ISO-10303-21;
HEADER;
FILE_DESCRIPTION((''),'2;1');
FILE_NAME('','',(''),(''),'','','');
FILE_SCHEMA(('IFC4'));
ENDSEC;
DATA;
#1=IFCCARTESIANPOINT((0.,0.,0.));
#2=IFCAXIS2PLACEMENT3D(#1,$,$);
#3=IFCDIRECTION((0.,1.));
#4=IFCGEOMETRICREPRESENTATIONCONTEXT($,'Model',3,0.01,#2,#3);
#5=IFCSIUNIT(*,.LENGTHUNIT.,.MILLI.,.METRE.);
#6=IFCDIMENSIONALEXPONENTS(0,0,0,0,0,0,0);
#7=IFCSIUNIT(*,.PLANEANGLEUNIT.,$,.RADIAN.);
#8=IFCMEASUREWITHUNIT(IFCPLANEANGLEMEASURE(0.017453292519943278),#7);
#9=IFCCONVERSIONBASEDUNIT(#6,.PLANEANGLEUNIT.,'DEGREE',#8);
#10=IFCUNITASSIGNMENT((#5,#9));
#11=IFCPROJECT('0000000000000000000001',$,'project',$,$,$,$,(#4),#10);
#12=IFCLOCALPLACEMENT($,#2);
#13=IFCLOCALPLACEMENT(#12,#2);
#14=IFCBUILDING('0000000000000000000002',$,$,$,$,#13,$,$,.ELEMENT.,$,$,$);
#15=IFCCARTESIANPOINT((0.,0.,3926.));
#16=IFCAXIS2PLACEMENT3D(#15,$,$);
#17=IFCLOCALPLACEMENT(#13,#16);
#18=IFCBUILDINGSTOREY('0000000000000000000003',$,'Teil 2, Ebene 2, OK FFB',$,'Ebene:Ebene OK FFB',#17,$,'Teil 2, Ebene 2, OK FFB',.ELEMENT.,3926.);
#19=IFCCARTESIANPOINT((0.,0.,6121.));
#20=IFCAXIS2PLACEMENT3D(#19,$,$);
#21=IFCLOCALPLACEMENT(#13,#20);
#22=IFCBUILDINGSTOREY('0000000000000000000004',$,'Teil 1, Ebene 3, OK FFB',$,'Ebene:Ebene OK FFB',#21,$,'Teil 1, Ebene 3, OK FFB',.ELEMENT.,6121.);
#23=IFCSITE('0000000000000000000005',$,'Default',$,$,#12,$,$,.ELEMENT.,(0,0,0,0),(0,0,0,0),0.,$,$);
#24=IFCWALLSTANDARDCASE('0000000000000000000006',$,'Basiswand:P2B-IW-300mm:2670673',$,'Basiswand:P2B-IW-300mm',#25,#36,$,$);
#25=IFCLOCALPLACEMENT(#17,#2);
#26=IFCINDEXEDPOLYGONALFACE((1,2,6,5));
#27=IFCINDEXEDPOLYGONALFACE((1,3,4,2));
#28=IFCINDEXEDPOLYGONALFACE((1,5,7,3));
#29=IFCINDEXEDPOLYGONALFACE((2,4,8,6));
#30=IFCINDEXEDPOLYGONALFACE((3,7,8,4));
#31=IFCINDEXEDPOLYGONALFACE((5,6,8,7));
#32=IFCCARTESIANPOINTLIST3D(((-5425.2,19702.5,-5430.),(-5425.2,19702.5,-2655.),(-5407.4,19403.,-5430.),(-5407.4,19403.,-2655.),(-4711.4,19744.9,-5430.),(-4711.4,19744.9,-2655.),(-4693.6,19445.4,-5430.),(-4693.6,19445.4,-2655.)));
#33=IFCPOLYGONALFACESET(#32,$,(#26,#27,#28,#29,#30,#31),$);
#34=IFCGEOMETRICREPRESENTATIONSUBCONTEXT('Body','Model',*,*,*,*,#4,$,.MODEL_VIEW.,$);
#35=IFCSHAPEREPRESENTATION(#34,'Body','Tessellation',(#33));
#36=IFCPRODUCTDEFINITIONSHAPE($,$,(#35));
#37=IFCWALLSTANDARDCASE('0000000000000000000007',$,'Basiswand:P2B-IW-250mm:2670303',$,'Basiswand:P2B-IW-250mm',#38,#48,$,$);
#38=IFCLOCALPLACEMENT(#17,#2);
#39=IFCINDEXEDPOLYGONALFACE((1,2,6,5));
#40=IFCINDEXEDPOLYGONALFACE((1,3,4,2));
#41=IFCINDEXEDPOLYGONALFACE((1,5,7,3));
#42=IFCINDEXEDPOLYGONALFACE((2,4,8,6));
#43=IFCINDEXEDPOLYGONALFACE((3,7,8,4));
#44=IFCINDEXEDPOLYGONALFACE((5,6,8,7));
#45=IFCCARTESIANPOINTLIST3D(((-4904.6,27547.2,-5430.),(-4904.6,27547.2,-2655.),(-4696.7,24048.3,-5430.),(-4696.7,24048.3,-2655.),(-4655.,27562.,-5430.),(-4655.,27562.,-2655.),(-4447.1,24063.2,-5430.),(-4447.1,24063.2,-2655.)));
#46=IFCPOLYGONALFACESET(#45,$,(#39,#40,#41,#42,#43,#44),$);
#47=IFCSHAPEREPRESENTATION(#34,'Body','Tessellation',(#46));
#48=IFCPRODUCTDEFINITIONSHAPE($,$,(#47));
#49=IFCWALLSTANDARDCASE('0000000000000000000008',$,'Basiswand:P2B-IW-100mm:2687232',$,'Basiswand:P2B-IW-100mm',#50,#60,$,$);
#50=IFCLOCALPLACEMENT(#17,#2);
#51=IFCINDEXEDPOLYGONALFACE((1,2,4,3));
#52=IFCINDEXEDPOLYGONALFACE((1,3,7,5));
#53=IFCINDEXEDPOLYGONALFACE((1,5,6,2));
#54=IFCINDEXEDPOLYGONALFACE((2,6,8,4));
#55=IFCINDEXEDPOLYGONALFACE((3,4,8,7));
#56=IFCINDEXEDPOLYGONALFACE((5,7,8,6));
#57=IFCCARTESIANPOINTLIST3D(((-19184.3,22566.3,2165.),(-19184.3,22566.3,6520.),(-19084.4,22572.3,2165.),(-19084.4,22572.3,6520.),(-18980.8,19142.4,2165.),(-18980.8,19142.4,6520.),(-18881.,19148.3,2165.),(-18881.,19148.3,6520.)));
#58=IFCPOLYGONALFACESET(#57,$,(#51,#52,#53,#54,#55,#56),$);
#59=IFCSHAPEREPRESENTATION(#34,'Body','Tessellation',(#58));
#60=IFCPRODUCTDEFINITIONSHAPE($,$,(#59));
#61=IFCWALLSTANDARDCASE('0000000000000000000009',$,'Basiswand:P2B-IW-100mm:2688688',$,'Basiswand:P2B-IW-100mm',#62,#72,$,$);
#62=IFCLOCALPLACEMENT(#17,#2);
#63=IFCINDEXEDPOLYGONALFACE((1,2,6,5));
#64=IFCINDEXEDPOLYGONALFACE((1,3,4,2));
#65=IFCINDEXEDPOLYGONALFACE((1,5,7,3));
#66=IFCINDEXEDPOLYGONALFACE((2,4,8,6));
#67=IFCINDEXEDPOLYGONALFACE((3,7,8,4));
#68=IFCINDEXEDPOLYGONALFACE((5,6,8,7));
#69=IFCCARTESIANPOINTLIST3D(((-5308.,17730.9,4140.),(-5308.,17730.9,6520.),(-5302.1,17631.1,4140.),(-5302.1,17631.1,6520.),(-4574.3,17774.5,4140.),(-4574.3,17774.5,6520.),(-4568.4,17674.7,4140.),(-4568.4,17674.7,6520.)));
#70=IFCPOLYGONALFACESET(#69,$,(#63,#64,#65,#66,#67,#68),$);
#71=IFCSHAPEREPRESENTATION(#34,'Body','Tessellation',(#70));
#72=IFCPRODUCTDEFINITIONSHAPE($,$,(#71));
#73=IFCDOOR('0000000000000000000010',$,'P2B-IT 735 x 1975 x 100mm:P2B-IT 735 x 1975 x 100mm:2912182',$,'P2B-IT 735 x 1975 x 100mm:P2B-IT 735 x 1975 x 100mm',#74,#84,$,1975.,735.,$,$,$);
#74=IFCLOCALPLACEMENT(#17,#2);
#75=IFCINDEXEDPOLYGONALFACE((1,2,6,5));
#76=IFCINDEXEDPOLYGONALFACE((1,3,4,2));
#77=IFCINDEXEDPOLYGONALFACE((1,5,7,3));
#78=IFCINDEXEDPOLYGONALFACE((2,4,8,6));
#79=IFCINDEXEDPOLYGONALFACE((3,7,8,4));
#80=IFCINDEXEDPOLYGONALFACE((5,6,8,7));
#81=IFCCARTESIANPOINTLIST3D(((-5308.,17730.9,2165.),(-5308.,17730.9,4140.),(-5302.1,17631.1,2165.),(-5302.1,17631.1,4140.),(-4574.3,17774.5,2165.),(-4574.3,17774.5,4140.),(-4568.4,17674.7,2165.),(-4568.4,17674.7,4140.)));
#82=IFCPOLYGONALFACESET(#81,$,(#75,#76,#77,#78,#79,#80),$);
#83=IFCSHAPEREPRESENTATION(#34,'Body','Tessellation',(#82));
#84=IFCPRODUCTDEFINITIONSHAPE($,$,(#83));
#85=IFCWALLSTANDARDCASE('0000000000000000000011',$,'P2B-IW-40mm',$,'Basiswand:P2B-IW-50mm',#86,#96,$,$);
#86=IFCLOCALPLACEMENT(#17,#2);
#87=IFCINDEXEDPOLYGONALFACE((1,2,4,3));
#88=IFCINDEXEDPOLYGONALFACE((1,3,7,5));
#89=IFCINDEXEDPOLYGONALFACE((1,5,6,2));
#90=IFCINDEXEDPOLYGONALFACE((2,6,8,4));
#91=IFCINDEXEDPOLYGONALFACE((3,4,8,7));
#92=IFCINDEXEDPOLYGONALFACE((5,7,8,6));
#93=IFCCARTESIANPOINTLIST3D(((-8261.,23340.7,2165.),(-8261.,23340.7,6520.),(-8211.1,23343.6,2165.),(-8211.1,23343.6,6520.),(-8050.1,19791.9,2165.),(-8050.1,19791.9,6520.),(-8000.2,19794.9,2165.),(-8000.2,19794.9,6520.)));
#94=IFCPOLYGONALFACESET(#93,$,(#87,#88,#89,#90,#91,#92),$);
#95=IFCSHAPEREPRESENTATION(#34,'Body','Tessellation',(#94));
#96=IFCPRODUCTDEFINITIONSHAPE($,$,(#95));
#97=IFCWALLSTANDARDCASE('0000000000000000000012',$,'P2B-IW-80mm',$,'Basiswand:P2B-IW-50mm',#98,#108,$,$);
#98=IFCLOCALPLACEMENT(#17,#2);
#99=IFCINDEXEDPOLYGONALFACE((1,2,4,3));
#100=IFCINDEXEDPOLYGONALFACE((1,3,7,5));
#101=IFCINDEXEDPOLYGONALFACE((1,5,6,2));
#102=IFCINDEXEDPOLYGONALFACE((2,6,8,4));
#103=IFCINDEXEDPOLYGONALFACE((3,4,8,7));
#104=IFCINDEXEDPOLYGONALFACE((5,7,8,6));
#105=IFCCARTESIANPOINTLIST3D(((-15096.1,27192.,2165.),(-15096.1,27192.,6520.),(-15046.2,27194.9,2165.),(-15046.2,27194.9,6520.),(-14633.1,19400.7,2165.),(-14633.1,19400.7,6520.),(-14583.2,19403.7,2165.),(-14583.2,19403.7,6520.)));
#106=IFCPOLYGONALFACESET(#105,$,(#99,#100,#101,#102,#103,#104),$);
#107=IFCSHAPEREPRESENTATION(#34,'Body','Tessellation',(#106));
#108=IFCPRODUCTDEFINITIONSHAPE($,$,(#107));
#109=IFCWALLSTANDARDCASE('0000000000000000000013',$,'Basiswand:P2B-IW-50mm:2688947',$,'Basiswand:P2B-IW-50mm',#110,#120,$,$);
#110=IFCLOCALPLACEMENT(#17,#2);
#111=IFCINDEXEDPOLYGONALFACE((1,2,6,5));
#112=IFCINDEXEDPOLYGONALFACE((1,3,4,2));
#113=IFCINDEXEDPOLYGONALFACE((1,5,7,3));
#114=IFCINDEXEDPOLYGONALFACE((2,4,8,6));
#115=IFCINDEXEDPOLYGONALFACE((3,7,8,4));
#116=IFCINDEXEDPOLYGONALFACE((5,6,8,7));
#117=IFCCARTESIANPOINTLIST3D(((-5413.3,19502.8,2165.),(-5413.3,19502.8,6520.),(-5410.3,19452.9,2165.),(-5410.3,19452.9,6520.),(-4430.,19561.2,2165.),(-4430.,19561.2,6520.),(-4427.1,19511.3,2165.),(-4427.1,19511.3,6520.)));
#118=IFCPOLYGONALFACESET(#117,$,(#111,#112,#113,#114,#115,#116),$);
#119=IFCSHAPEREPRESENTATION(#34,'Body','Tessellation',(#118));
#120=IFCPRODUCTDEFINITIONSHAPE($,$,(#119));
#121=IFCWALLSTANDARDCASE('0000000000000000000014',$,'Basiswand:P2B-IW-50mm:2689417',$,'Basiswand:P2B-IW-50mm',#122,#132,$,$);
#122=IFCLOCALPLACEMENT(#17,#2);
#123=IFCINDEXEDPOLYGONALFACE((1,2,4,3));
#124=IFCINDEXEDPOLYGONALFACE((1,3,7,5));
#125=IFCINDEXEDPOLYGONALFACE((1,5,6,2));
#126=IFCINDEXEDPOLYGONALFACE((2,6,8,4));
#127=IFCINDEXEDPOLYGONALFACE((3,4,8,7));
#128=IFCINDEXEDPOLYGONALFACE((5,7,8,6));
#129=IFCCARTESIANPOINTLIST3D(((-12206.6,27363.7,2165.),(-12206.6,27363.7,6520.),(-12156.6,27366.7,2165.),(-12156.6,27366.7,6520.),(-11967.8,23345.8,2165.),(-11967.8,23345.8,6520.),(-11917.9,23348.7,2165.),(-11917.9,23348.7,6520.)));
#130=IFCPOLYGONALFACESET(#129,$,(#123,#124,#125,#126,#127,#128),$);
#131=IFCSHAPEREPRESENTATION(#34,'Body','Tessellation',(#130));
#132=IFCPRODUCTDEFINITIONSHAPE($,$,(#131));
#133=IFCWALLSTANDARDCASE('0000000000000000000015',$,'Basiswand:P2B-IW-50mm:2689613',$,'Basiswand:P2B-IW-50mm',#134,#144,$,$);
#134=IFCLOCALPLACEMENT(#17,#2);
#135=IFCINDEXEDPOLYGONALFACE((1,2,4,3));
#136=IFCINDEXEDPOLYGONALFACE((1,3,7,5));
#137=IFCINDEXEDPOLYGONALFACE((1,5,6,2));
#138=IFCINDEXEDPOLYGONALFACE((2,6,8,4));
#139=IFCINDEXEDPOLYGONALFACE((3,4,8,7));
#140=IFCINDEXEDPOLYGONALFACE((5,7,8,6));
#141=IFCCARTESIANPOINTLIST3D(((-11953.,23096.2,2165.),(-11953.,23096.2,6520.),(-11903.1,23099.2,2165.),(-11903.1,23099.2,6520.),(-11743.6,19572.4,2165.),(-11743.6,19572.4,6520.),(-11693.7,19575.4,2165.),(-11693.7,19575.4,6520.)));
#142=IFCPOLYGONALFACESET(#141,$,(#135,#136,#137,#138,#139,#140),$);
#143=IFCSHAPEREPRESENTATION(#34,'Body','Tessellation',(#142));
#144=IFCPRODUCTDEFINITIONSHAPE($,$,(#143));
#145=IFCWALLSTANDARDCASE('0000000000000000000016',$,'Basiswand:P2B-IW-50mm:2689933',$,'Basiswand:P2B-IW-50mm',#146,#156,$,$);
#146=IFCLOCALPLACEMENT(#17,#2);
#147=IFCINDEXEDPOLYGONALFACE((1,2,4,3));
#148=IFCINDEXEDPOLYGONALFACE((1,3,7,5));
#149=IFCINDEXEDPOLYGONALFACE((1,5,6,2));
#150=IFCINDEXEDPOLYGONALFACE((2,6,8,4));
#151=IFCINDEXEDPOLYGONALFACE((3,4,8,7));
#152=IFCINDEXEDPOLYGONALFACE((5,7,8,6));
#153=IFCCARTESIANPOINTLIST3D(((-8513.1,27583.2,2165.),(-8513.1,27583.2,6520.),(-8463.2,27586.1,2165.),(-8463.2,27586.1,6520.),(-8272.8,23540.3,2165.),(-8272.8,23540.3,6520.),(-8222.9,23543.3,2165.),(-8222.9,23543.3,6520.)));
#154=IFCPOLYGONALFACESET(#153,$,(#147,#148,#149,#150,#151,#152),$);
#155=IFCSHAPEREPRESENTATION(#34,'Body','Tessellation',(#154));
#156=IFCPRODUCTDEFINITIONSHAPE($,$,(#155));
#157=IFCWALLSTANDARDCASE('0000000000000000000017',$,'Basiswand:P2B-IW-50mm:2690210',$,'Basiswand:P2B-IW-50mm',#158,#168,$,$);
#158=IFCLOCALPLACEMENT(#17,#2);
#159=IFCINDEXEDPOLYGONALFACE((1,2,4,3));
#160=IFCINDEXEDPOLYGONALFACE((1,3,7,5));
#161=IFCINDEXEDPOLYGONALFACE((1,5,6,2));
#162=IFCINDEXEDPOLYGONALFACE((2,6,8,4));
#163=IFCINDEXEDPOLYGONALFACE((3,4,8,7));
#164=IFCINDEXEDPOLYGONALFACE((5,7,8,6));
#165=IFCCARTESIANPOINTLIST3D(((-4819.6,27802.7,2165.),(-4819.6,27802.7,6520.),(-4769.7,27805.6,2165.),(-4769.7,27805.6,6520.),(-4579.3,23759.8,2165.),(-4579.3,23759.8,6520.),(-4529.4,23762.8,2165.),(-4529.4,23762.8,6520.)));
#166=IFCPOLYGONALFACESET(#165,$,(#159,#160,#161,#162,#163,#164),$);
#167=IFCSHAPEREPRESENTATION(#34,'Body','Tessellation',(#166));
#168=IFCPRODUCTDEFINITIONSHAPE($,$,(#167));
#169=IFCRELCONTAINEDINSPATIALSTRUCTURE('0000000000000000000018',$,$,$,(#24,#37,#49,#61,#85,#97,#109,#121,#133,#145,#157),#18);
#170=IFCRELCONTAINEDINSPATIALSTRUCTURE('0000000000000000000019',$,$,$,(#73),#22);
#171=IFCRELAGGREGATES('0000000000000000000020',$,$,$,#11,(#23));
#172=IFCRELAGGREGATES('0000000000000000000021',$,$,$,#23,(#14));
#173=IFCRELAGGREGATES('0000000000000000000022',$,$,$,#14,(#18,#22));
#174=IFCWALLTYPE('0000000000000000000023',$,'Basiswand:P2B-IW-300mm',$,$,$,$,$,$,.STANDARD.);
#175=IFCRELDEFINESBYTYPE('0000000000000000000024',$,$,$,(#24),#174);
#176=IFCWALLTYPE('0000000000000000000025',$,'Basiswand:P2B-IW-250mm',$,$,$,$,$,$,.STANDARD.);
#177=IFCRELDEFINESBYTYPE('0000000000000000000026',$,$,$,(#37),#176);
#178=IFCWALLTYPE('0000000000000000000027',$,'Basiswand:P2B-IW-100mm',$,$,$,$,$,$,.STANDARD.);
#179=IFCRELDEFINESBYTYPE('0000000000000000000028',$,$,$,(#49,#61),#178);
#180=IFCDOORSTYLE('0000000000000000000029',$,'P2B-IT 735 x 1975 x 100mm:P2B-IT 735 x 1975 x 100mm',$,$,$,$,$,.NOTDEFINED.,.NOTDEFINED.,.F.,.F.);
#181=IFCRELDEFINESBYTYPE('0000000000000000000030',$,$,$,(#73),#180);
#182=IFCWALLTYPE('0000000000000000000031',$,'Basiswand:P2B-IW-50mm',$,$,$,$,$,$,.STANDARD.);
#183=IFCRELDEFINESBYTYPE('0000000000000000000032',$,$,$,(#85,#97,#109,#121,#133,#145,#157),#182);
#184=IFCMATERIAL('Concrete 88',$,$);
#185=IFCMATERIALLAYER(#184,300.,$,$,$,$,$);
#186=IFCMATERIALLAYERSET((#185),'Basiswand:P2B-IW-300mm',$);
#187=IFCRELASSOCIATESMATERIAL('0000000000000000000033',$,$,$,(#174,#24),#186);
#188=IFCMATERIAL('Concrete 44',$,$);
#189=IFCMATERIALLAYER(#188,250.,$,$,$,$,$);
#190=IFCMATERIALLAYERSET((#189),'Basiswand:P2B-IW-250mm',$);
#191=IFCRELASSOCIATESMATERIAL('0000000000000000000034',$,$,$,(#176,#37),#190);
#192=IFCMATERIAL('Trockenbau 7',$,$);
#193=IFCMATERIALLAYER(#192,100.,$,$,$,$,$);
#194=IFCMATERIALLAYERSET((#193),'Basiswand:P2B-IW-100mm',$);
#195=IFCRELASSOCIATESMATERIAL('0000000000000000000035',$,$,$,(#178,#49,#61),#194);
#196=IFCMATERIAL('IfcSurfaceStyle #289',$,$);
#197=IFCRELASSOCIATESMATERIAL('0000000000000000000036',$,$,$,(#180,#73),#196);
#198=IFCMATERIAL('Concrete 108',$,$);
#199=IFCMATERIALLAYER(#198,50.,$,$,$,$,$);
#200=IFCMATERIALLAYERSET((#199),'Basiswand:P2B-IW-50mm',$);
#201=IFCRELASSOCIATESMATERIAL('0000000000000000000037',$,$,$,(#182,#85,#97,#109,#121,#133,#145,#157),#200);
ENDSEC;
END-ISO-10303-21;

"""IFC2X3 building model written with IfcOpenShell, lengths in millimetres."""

from ifc_helpers import new_model, entity, si_unit, converted_unit, direction, frame, frame_2d, origin, origin_2d_with_axis, place, context, subcontext, project, spatial, rectangle, extrude, source, transform, mapped, material, layer, layer_set, layer_usage, type_object, type_shapes, element, fill, save


model = new_model("IFC2X3")

# Units and contexts
model_context = context("Model", 3, precision=0.01, world=origin(), true_north=direction((0.0, 1.0)))
body_context = subcontext(model_context, "Body", "Model", "MODEL_VIEW")
ifc_project = project(units=[si_unit("LENGTHUNIT", "METRE", prefix="MILLI"), converted_unit("PLANEANGLEUNIT", "DEGREE", entity("IfcPlaneAngleMeasure", 0.017453292519943278), si_unit("PLANEANGLEUNIT", "RADIAN"), dimensions=[0, 0, 0, 0, 0, 0, 0])], contexts=[model_context])

# Site, building, storey
site_placement = place(None, origin())
site = spatial("IfcSite", under=ifc_project, at=site_placement, Name="Default", CompositionType="ELEMENT", RefLatitude=(0, 0, 0, 0), RefLongitude=(0, 0, 0, 0), RefElevation=0.0)
building_placement = place(site_placement, origin())
building = spatial("IfcBuilding", under=site, at=building_placement, CompositionType="ELEMENT")
storey_1_placement = place(building_placement, frame((0.0, 0.0, 3926.0)))
storey_1 = spatial("IfcBuildingStorey", under=building, at=storey_1_placement, Name="Teil 2, Ebene 2, OK FFB", ObjectType="Ebene:Ebene OK FFB", LongName="Teil 2, Ebene 2, OK FFB", CompositionType="ELEMENT", Elevation=3926.0)

# Walls
ifc_material_1 = material(Name="Concrete 88")
ifc_layer_1 = layer(ifc_material_1, 300.0)
ifc_layer_set_1 = layer_set([ifc_layer_1], Name="Basiswand:P2B-IW-300mm")
ifc_layer_usage_1 = layer_usage(ifc_layer_set_1, "AXIS2", "NEGATIVE", 150.0)
wall_type_1 = type_object("IfcWallType", Name="Basiswand:P2B-IW-300mm", PredefinedType="STANDARD", material=ifc_layer_set_1)
wall_1_placement = place(storey_1_placement, frame((-4702.5, 19595.1, -5430.0), z_axis=(0.0, 0.0, 1.0), x_axis=(-0.998239, -0.059319, 0.0)))
element("IfcWallStandardCase", 1, at=wall_1_placement, inside=storey_1, type_object=wall_type_1, material=ifc_layer_usage_1, Name="Basiswand:P2B-IW-300mm:2670673", ObjectType="Basiswand:P2B-IW-300mm", context=body_context, shape_type="SweptSolid", body=[
    extrude(rectangle(XDim=715.0, YDim=300.0, at=frame_2d((357.5, 0.0), x_axis=(-1.0, 0.0))), origin(), (0.0, 0.0, 1.0), 2775.0),
])
ifc_material_2 = material(Name="Concrete 44")
ifc_layer_2 = layer(ifc_material_2, 250.0)
ifc_layer_set_2 = layer_set([ifc_layer_2], Name="Basiswand:P2B-IW-250mm")
ifc_layer_usage_2 = layer_usage(ifc_layer_set_2, "AXIS2", "NEGATIVE", 125.0)
wall_type_2 = type_object("IfcWallType", Name="Basiswand:P2B-IW-250mm", PredefinedType="STANDARD", material=ifc_layer_set_2)
wall_2_placement = place(storey_1_placement, frame((-4571.9, 24055.7, -5430.0), z_axis=(0.0, 0.0, 1.0), x_axis=(-0.059319, 0.998239, 0.0)))
element("IfcWallStandardCase", 2, at=wall_2_placement, inside=storey_1, type_object=wall_type_2, material=ifc_layer_usage_2, Name="Basiswand:P2B-IW-250mm:2670303", ObjectType="Basiswand:P2B-IW-250mm", context=body_context, shape_type="SweptSolid", body=[
    extrude(rectangle(XDim=3505.0, YDim=250.0, at=frame_2d((1752.5, 0.0), x_axis=(-1.0, 0.0))), origin(), (0.0, 0.0, 1.0), 2775.0),
])
ifc_material_3 = material(Name="Trockenbau 7")
ifc_layer_3 = layer(ifc_material_3, 100.0)
ifc_layer_set_3 = layer_set([ifc_layer_3], Name="Basiswand:P2B-IW-100mm")
ifc_layer_usage_3 = layer_usage(ifc_layer_set_3, "AXIS2", "NEGATIVE", 50.0)
wall_type_3 = type_object("IfcWallType", Name="Basiswand:P2B-IW-100mm", PredefinedType="STANDARD", material=ifc_layer_set_3)
wall_3_placement = place(storey_1_placement, frame((-18930.9, 19145.3, 2165.0), z_axis=(0.0, 0.0, 1.0), x_axis=(-0.059319, 0.998239, 0.0)))
element("IfcWallStandardCase", 3, at=wall_3_placement, inside=storey_1, type_object=wall_type_3, material=ifc_layer_usage_3, Name="Basiswand:P2B-IW-100mm:2687232", ObjectType="Basiswand:P2B-IW-100mm", context=body_context, shape_type="SweptSolid", body=[
    extrude(rectangle(XDim=3430.0, YDim=100.0, at=frame_2d((1715.0, 0.0), x_axis=(-1.0, 0.0))), origin(), (0.0, 0.0, 1.0), 4355.0),
])

# Wall, opening
ifc_layer_usage_4 = layer_usage(ifc_layer_set_3, "AXIS2", "NEGATIVE", 50.0)
wall_4_placement = place(storey_1_placement, frame((-4571.3, 17724.6, 4140.0), z_axis=(0.0, 0.0, 1.0), x_axis=(-0.998239, -0.059319, 0.0)))
wall_4 = element("IfcWallStandardCase", 4, at=wall_4_placement, inside=storey_1, type_object=wall_type_3, material=ifc_layer_usage_4, Name="Basiswand:P2B-IW-100mm:2688688", ObjectType="Basiswand:P2B-IW-100mm", context=body_context, shape_type="SweptSolid", body=[
    extrude(rectangle(XDim=735.0, YDim=100.0, at=frame_2d((367.5, 0.0), x_axis=(-1.0, 0.0))), origin(), (0.0, 0.0, 1.0), 2380.0),
])
opening_1_placement = place(wall_4_placement, frame((-3511.9, 17964.6, -1945.0), z_axis=(0.0, 0.0, 1.0), x_axis=(-0.998239, 0.059319, 0.0)))
opening_1 = element("IfcOpeningElement", 5, at=opening_1_placement, cuts=wall_4, ObjectType="Opening", context=body_context, shape_type="SweptSolid", body=[
    extrude(rectangle(XDim=1975.0, YDim=735.0, at=frame_2d((0.0, 0.0), x_axis=(1.0, 0.0))), frame((-4941.1, 17752.7, 957.5), z_axis=(0.059319, -0.998239, 0.0), x_axis=(0.0, 0.0, -1.0)), (0.0, 0.0, 1.0), 100.0),
])

# Shared definitions
storey_2_placement = place(building_placement, frame((0.0, 0.0, 6121.0)))
storey_2 = spatial("IfcBuildingStorey", under=building, at=storey_2_placement, Name="Teil 1, Ebene 3, OK FFB", ObjectType="Ebene:Ebene OK FFB", LongName="Teil 1, Ebene 3, OK FFB", CompositionType="ELEMENT", Elevation=6121.0)

# Door
ifc_material_4 = material(Name="IfcSurfaceStyle #289")
door_style = type_object("IfcDoorStyle", Name="P2B-IT 735 x 1975 x 100mm:P2B-IT 735 x 1975 x 100mm", ConstructionType="NOTDEFINED", OperationType="NOTDEFINED", ParameterTakesPrecedence=False, Sizeable=False, material=ifc_material_4)
shared_shape = source(origin(), body_context, "Body", "SweptSolid", [
    extrude(rectangle(XDim=100.0, YDim=735.0, at=origin_2d_with_axis()), frame((367.5, -50.0, 0.0), z_axis=(0.0, 0.0, 1.0), x_axis=(0.0, 1.0, 0.0)), (0.0, 0.0, 1.0), 1975.0),
])
type_shapes(door_style, [shared_shape])
door_placement = place(opening_1_placement, frame((-4568.4, 17674.7, -30.0), z_axis=(0.0, 0.0, 1.0), x_axis=(-0.998239, -0.059319, 0.0)))
door = element("IfcDoor", 6, at=door_placement, inside=storey_2, type_object=door_style, material=ifc_material_4, Name="P2B-IT 735 x 1975 x 100mm:P2B-IT 735 x 1975 x 100mm:2912182", ObjectType="P2B-IT 735 x 1975 x 100mm:P2B-IT 735 x 1975 x 100mm", OverallHeight=1975.0, OverallWidth=735.0, context=body_context, shape_type="MappedRepresentation", body=[
    mapped(shared_shape, transform((0.0, 0.0, 0.0), scale=1.0)),
])
fill(opening_1, door)

# Walls
ifc_material_5 = material(Name="Concrete 108")
ifc_layer_4 = layer(ifc_material_5, 50.0)
ifc_layer_set_4 = layer_set([ifc_layer_4], Name="Basiswand:P2B-IW-50mm")
ifc_layer_usage_5 = layer_usage(ifc_layer_set_4, "AXIS2", "NEGATIVE", 25.0)
wall_type_4 = type_object("IfcWallType", Name="Basiswand:P2B-IW-50mm", PredefinedType="STANDARD", material=ifc_layer_set_4)
wall_5_placement = place(storey_1_placement, frame((-8025.1, 19793.4, 2165.0), z_axis=(0.0, 0.0, 1.0), x_axis=(-0.059319, 0.998239, 0.0)))
element("IfcWallStandardCase", 7, at=wall_5_placement, inside=storey_1, type_object=wall_type_4, material=ifc_layer_usage_5, Name="P2B-IW-40mm", ObjectType="Basiswand:P2B-IW-50mm", context=body_context, shape_type="SweptSolid", body=[
    extrude(rectangle(XDim=3555.0, YDim=50.0, at=frame_2d((1777.5, 0.0), x_axis=(-1.0, 0.0))), origin(), (0.0, 0.0, 1.0), 4355.0),
])
ifc_layer_usage_6 = layer_usage(ifc_layer_set_4, "AXIS2", "NEGATIVE", 25.0)
wall_6_placement = place(storey_1_placement, frame((-14608.2, 19402.2, 2165.0), z_axis=(0.0, 0.0, 1.0), x_axis=(-0.059319, 0.998239, 0.0)))
element("IfcWallStandardCase", 8, at=wall_6_placement, inside=storey_1, type_object=wall_type_4, material=ifc_layer_usage_6, Name="P2B-IW-80mm", ObjectType="Basiswand:P2B-IW-50mm", context=body_context, shape_type="SweptSolid", body=[
    extrude(rectangle(XDim=7805.0, YDim=50.0, at=frame_2d((3902.5, 0.0), x_axis=(-1.0, 0.0))), origin(), (0.0, 0.0, 1.0), 4355.0),
])
ifc_layer_usage_7 = layer_usage(ifc_layer_set_4, "AXIS2", "POSITIVE", -25.0)
wall_7_placement = place(storey_1_placement, frame((-4428.5, 19536.3, 2165.0), z_axis=(0.0, 0.0, 1.0), x_axis=(-0.998239, -0.059319, 0.0)))
element("IfcWallStandardCase", 9, at=wall_7_placement, inside=storey_1, type_object=wall_type_4, material=ifc_layer_usage_7, Name="Basiswand:P2B-IW-50mm:2688947", ObjectType="Basiswand:P2B-IW-50mm", context=body_context, shape_type="SweptSolid", body=[
    extrude(rectangle(XDim=985.0, YDim=50.0, at=frame_2d((492.5, 0.0), x_axis=(-1.0, 0.0))), origin(), (0.0, 0.0, 1.0), 4355.0),
])
ifc_layer_usage_8 = layer_usage(ifc_layer_set_4, "AXIS2", "NEGATIVE", 25.0)
wall_8_placement = place(storey_1_placement, frame((-11942.8, 23347.3, 2165.0), z_axis=(0.0, 0.0, 1.0), x_axis=(-0.059319, 0.998239, 0.0)))
element("IfcWallStandardCase", 10, at=wall_8_placement, inside=storey_1, type_object=wall_type_4, material=ifc_layer_usage_8, Name="Basiswand:P2B-IW-50mm:2689417", ObjectType="Basiswand:P2B-IW-50mm", context=body_context, shape_type="SweptSolid", body=[
    extrude(rectangle(XDim=4025.0, YDim=50.0, at=frame_2d((2012.5, 0.0), x_axis=(-1.0, 0.0))), origin(), (0.0, 0.0, 1.0), 4355.0),
])
ifc_layer_usage_9 = layer_usage(ifc_layer_set_4, "AXIS2", "NEGATIVE", 25.0)
wall_9_placement = place(storey_1_placement, frame((-11718.6, 19573.9, 2165.0), z_axis=(0.0, 0.0, 1.0), x_axis=(-0.059319, 0.998239, 0.0)))
element("IfcWallStandardCase", 11, at=wall_9_placement, inside=storey_1, type_object=wall_type_4, material=ifc_layer_usage_9, Name="Basiswand:P2B-IW-50mm:2689613", ObjectType="Basiswand:P2B-IW-50mm", context=body_context, shape_type="SweptSolid", body=[
    extrude(rectangle(XDim=3530.0, YDim=50.0, at=frame_2d((1765.0, 0.0), x_axis=(-1.0, 0.0))), origin(), (0.0, 0.0, 1.0), 4355.0),
])
ifc_layer_usage_10 = layer_usage(ifc_layer_set_4, "AXIS2", "NEGATIVE", 25.0)
wall_10_placement = place(storey_1_placement, frame((-8247.9, 23541.8, 2165.0), z_axis=(0.0, 0.0, 1.0), x_axis=(-0.059319, 0.998239, 0.0)))
element("IfcWallStandardCase", 12, at=wall_10_placement, inside=storey_1, type_object=wall_type_4, material=ifc_layer_usage_10, Name="Basiswand:P2B-IW-50mm:2689933", ObjectType="Basiswand:P2B-IW-50mm", context=body_context, shape_type="SweptSolid", body=[
    extrude(rectangle(XDim=4050.0, YDim=50.0, at=frame_2d((2025.0, 0.0), x_axis=(-1.0, 0.0))), origin(), (0.0, 0.0, 1.0), 4355.0),
])
ifc_layer_usage_11 = layer_usage(ifc_layer_set_4, "AXIS2", "NEGATIVE", 25.0)
wall_11_placement = place(storey_1_placement, frame((-4554.4, 23761.3, 2165.0), z_axis=(0.0, 0.0, 1.0), x_axis=(-0.059319, 0.998239, 0.0)))
element("IfcWallStandardCase", 13, at=wall_11_placement, inside=storey_1, type_object=wall_type_4, material=ifc_layer_usage_11, Name="Basiswand:P2B-IW-50mm:2690210", ObjectType="Basiswand:P2B-IW-50mm", context=body_context, shape_type="SweptSolid", body=[
    extrude(rectangle(XDim=4050.0, YDim=50.0, at=frame_2d((2025.0, 0.0), x_axis=(-1.0, 0.0))), origin(), (0.0, 0.0, 1.0), 4355.0),
])

save(model, "model.ifc")
